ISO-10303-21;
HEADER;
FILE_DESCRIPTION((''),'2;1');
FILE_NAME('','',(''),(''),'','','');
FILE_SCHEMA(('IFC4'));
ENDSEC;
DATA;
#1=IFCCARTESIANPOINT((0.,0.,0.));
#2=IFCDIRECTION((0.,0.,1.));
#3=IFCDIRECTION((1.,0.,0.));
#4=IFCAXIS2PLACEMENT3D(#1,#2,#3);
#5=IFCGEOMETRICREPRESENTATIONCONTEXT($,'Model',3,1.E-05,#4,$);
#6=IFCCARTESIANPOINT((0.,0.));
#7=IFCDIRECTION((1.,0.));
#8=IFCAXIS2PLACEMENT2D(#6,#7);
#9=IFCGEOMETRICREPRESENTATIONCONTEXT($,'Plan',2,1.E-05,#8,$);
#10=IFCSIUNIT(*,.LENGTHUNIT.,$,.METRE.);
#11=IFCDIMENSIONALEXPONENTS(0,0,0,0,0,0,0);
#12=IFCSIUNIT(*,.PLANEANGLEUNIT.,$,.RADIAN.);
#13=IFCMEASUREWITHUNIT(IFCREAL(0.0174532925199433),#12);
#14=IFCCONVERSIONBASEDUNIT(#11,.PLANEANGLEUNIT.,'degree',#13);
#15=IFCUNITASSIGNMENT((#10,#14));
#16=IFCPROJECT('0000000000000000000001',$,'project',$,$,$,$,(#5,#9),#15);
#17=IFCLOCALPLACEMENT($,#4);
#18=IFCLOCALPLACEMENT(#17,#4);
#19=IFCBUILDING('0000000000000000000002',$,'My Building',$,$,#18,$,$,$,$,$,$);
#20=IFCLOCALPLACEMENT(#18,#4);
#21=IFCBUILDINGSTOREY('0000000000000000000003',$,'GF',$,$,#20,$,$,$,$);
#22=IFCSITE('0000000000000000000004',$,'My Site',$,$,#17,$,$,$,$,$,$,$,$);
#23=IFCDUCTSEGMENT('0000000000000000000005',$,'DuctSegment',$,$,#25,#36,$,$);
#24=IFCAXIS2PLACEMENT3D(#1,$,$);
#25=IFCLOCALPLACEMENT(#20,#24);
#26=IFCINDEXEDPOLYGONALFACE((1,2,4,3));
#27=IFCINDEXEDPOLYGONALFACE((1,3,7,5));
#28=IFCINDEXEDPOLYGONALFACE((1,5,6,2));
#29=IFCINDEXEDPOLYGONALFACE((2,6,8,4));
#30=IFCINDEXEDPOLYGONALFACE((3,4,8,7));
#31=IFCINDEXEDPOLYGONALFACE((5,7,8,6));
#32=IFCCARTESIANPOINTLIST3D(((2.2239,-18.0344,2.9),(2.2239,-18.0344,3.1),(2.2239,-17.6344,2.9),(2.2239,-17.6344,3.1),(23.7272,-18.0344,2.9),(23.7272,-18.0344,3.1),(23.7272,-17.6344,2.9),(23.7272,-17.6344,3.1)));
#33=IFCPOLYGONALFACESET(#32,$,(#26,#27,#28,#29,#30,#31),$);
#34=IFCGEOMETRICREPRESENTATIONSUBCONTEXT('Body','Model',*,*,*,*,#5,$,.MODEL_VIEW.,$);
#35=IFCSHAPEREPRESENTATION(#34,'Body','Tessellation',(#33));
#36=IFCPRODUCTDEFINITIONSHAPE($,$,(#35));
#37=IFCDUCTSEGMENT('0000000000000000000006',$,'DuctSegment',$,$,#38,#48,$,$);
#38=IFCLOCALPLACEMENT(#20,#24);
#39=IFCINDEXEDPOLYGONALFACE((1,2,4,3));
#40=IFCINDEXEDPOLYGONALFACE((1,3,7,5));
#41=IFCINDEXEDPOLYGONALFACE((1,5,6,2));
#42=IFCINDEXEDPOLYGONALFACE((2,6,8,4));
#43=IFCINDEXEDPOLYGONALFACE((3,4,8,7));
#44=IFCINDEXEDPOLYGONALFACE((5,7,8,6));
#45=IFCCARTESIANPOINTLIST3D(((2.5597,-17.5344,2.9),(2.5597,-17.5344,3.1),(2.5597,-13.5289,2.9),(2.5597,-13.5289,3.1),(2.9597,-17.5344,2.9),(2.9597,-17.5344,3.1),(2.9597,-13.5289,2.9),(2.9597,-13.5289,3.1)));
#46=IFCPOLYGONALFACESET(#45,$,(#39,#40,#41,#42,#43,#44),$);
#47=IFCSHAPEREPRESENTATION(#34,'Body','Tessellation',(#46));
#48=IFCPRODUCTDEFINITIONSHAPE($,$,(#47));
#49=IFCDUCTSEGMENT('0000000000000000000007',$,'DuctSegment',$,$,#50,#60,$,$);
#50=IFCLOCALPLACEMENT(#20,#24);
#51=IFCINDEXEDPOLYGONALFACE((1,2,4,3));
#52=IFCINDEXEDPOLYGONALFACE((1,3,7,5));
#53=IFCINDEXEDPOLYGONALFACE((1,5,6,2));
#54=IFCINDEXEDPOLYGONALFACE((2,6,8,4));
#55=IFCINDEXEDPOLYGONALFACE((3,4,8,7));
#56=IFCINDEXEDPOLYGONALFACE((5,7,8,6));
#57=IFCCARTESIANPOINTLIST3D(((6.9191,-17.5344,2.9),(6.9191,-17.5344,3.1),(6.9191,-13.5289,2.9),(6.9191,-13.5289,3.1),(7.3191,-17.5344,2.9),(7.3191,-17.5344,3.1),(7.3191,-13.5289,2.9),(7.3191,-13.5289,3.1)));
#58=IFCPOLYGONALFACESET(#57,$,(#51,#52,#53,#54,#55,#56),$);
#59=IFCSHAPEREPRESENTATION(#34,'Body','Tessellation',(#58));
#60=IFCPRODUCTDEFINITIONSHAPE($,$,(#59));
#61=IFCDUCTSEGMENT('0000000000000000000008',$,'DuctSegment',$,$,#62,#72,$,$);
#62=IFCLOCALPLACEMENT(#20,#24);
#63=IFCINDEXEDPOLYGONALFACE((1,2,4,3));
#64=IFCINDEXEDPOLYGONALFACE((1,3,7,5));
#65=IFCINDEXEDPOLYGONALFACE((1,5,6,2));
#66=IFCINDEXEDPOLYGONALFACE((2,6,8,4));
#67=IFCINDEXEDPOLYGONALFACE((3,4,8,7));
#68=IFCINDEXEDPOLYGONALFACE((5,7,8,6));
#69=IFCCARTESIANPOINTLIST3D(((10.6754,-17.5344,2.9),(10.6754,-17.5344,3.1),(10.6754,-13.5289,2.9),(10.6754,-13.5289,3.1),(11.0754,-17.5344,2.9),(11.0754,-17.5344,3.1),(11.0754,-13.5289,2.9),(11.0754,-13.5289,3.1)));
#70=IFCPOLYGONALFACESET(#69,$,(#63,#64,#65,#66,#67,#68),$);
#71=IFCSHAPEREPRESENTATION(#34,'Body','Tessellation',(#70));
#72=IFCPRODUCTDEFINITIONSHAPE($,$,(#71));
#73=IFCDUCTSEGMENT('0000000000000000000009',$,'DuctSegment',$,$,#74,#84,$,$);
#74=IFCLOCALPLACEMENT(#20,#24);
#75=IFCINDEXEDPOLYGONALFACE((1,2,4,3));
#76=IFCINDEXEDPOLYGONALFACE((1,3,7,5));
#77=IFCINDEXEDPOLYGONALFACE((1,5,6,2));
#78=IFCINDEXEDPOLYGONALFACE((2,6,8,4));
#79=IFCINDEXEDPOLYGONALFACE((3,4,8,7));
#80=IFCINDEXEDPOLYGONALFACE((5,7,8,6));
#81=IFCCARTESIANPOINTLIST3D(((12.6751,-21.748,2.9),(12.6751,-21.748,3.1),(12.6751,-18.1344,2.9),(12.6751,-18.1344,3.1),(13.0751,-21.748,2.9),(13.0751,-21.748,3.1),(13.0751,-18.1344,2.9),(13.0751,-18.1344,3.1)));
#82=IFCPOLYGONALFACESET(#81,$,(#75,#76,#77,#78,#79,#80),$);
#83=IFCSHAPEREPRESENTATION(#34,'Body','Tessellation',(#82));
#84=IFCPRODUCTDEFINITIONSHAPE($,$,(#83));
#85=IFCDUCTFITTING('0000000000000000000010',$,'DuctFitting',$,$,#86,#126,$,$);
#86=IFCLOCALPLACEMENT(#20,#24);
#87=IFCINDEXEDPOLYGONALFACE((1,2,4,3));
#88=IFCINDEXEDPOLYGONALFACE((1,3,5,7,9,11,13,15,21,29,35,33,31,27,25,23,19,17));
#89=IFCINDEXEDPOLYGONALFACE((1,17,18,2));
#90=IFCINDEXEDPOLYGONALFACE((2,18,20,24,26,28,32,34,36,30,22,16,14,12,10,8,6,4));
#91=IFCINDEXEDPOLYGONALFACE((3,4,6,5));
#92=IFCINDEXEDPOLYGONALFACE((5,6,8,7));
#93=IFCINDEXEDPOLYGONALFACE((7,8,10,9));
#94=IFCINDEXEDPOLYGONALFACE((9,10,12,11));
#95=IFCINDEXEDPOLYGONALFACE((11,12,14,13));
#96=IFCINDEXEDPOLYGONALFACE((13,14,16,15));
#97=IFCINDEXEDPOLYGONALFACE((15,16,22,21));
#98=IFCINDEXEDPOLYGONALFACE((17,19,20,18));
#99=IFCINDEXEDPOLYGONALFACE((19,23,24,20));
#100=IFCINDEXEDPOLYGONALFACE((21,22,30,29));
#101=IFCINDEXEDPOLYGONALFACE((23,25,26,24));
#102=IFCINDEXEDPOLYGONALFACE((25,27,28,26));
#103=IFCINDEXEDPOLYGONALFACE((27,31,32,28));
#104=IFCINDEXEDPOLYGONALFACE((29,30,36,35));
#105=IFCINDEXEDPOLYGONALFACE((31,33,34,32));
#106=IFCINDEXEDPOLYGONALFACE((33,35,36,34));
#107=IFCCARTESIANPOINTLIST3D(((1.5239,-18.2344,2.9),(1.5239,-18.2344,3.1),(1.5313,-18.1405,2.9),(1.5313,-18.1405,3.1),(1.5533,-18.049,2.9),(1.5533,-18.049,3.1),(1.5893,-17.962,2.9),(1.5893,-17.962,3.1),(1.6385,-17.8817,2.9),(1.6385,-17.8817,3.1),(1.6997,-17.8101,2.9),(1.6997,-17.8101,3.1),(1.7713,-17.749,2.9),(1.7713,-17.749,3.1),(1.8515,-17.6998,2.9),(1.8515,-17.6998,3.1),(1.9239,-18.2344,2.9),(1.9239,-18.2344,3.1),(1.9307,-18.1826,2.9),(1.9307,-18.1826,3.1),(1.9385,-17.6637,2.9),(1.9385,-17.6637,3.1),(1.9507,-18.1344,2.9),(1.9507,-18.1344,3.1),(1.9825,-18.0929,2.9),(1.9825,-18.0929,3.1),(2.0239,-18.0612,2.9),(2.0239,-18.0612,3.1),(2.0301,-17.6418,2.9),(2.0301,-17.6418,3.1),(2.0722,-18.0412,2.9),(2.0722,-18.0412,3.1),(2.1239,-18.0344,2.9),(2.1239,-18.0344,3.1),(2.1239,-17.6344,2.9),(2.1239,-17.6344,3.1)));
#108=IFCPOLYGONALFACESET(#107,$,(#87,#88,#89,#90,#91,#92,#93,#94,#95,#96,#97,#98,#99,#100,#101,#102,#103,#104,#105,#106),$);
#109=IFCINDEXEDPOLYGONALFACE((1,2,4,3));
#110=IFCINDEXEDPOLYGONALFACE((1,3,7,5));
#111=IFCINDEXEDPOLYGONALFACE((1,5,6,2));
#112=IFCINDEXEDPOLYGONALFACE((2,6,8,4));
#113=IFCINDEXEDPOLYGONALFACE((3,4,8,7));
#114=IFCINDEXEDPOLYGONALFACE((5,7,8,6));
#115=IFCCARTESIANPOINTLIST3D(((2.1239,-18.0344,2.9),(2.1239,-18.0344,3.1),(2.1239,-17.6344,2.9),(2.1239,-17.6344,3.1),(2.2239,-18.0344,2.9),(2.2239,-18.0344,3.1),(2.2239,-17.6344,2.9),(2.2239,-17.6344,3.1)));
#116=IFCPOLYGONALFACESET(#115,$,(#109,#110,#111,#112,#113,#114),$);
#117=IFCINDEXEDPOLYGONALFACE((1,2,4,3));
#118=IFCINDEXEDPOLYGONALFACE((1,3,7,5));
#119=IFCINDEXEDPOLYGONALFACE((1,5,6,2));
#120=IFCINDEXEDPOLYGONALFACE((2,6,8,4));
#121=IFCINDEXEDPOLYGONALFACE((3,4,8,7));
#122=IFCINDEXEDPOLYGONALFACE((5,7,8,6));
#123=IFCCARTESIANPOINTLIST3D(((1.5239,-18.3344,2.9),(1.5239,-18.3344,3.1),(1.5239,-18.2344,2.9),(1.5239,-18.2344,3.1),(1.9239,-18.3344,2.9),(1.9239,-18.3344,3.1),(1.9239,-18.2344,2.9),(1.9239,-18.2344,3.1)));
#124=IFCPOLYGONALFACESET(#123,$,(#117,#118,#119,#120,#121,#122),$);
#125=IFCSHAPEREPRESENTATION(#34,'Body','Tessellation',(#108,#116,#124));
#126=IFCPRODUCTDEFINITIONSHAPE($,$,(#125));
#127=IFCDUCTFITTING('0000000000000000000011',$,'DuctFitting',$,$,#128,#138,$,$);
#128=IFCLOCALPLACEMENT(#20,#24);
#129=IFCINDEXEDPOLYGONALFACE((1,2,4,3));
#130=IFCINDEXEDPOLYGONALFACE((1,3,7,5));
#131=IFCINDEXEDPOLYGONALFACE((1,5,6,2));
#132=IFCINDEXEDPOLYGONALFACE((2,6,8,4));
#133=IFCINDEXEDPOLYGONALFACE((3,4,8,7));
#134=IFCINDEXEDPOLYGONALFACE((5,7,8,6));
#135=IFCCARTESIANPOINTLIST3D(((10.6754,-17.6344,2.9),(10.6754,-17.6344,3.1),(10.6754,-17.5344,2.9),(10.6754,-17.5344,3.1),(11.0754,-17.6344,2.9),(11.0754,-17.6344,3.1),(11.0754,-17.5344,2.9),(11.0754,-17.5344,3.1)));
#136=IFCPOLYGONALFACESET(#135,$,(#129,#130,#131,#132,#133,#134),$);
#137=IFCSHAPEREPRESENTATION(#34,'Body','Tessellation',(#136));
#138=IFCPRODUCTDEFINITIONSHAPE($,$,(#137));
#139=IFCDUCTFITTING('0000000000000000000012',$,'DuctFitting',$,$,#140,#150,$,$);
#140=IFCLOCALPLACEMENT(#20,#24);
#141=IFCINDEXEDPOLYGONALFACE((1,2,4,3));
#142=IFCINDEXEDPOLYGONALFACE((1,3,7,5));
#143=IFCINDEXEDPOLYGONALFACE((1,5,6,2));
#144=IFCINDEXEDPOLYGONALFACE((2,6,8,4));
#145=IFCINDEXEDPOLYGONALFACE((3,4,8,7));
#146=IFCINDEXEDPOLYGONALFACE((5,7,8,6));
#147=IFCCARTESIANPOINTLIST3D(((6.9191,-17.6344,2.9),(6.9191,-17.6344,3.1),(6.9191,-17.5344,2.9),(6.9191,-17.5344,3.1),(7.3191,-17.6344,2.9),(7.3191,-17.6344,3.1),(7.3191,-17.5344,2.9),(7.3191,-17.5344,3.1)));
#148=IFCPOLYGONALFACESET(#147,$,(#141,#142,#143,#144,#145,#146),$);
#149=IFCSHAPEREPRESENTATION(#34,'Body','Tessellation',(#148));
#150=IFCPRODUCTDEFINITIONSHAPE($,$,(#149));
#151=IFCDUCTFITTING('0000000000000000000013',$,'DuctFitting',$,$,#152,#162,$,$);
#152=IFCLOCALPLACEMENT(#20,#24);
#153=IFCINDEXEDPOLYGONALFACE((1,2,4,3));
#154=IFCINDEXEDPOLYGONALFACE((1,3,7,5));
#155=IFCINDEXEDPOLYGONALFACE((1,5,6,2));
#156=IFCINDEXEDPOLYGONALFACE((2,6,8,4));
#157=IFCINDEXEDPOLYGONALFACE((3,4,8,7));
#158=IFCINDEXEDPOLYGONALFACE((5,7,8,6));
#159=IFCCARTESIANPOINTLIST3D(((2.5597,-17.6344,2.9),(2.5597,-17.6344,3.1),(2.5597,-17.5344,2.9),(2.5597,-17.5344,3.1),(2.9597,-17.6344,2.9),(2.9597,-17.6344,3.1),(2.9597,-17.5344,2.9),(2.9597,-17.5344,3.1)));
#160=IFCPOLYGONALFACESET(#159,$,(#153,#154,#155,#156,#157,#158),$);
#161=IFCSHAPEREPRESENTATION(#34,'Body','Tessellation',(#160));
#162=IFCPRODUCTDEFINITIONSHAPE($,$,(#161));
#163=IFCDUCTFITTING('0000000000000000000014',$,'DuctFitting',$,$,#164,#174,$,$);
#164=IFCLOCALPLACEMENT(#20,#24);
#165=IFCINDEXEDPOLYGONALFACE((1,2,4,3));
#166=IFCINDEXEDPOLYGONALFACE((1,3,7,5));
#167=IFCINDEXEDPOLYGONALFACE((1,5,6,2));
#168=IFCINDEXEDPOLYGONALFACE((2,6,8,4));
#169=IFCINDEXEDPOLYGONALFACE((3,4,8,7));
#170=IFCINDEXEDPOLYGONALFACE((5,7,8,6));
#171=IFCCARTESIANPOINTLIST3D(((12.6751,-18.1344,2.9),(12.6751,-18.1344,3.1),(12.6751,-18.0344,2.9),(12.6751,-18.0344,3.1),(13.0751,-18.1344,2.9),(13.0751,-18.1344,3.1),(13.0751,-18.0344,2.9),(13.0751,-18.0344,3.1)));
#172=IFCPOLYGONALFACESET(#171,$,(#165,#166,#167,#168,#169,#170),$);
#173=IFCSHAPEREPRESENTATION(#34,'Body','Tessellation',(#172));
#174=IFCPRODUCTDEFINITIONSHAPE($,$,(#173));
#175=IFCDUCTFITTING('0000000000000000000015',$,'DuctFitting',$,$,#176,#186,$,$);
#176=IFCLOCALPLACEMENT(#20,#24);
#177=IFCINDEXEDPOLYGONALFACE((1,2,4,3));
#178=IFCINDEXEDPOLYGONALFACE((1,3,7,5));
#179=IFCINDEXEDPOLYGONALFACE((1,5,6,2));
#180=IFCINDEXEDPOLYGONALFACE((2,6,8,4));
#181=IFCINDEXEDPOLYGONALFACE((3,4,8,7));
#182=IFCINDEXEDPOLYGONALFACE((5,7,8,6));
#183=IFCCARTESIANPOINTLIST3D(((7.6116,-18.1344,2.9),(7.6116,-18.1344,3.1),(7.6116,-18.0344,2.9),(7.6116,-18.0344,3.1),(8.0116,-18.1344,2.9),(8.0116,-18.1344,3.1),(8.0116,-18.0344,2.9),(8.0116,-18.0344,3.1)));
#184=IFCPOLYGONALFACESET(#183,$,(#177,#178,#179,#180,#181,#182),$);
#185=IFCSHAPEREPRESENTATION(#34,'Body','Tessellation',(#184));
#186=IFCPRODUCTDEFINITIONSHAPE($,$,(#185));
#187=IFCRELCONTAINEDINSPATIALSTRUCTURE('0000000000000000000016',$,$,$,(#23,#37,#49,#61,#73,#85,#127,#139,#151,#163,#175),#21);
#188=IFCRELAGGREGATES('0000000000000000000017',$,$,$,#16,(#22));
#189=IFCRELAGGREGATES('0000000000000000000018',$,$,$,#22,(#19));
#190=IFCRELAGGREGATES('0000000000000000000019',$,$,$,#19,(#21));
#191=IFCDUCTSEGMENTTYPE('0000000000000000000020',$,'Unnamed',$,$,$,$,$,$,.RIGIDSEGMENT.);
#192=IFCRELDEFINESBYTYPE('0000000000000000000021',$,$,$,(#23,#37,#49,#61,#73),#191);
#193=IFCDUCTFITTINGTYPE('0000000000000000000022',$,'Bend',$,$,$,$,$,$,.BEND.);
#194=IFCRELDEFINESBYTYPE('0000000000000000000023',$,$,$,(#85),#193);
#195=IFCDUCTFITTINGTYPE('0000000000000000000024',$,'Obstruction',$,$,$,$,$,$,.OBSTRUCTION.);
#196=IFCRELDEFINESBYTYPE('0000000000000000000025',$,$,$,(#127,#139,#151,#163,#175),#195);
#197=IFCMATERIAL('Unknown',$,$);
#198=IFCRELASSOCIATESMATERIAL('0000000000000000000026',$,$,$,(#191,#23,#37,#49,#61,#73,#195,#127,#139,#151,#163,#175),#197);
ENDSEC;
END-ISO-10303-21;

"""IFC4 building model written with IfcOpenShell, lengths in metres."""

from ifc_helpers import new_model, entity, si_unit, converted_unit, frame, origin_with_axes, origin_2d_with_axis, place, context, subcontext, project, spatial, line, arc, indexed_curve, rectangle, outline, extrude, source, transform, mapped, material, material_profile, profile_set, profile_usage, type_object, type_shapes, element, save


model = new_model("IFC4")

# Units and contexts
model_context = context("Model", 3, precision=1e-05, world=origin_with_axes())
plan_context = context("Plan", 2, precision=1e-05, world=origin_2d_with_axis())
body_context_1 = subcontext(model_context, "Body", "Model", "MODEL_VIEW")
ifc_project = project(units=[si_unit("LENGTHUNIT", "METRE"), converted_unit("PLANEANGLEUNIT", "degree", entity("IfcReal", 0.0174532925199433), si_unit("PLANEANGLEUNIT", "RADIAN"), dimensions=[0, 0, 0, 0, 0, 0, 0])], contexts=[model_context, plan_context])

# Site, building, storey
site_placement = place(None, origin_with_axes())
site = spatial("IfcSite", under=ifc_project, at=site_placement, Name="My Site")
building_placement = place(site_placement, origin_with_axes())
building = spatial("IfcBuilding", under=site, at=building_placement, Name="My Building")
storey_placement = place(building_placement, origin_with_axes())
storey = spatial("IfcBuildingStorey", under=building, at=storey_placement, Name="GF")

# Shared definitions
ifc_material = material(Name="Unknown")

# Duct segments
ifc_material_profile_1 = material_profile(ifc_material, rectangle(XDim=0.4, YDim=0.2))
ifc_profile_set_1 = profile_set([ifc_material_profile_1])
ifc_profile_usage_1 = profile_usage(ifc_profile_set_1, cardinal=5)
duct_segment_type = type_object("IfcDuctSegmentType", Name="Unnamed", PredefinedType="RIGIDSEGMENT", material=ifc_profile_set_1)
duct_segment_1_placement = place(storey_placement, frame((2.2239, -17.8344, 3.0), z_axis=(1.0, -0.000001, 0.000001), x_axis=(0.000001, 1.0, 0.0)))
element("IfcDuctSegment", 1, at=duct_segment_1_placement, inside=storey, type_object=duct_segment_type, material=ifc_profile_usage_1, Name="DuctSegment", context=body_context_1, shape_type="SweptSolid", body=[
    extrude(rectangle(XDim=0.4, YDim=0.2), origin_with_axes(), (0.0, 0.0, 1.0), 21.5032),
])
ifc_profile_usage_2 = profile_usage(ifc_profile_set_1, cardinal=5)
duct_segment_2_placement = place(storey_placement, frame((2.7597, -17.5344, 3.0), z_axis=(0.0, 1.0, 0.0), x_axis=(-1.0, 0.0, 0.0)))
element("IfcDuctSegment", 2, at=duct_segment_2_placement, inside=storey, type_object=duct_segment_type, material=ifc_profile_usage_2, Name="DuctSegment", context=body_context_1, shape_type="SweptSolid", body=[
    extrude(rectangle(XDim=0.4, YDim=0.2), origin_with_axes(), (0.0, 0.0, 1.0), 4.0055),
])
ifc_profile_usage_3 = profile_usage(ifc_profile_set_1, cardinal=5)
duct_segment_3_placement = place(storey_placement, frame((7.1191, -17.5344, 3.0), z_axis=(0.0, 1.0, 0.0), x_axis=(-1.0, 0.0, 0.0)))
element("IfcDuctSegment", 3, at=duct_segment_3_placement, inside=storey, type_object=duct_segment_type, material=ifc_profile_usage_3, Name="DuctSegment", context=body_context_1, shape_type="SweptSolid", body=[
    extrude(rectangle(XDim=0.4, YDim=0.2), origin_with_axes(), (0.0, 0.0, 1.0), 4.0055),
])
ifc_profile_usage_4 = profile_usage(ifc_profile_set_1, cardinal=5)
duct_segment_4_placement = place(storey_placement, frame((10.8754, -17.5344, 3.0), z_axis=(0.0, 1.0, 0.0), x_axis=(-1.0, 0.0, 0.0)))
element("IfcDuctSegment", 4, at=duct_segment_4_placement, inside=storey, type_object=duct_segment_type, material=ifc_profile_usage_4, Name="DuctSegment", context=body_context_1, shape_type="SweptSolid", body=[
    extrude(rectangle(XDim=0.4, YDim=0.2), origin_with_axes(), (0.0, 0.0, 1.0), 4.0055),
])
ifc_profile_usage_5 = profile_usage(ifc_profile_set_1, cardinal=5)
duct_segment_5_placement = place(storey_placement, frame((12.8751, -18.1344, 3.0), z_axis=(0.0, -1.0, 0.0), x_axis=(1.0, 0.0, 0.0)))
element("IfcDuctSegment", 5, at=duct_segment_5_placement, inside=storey, type_object=duct_segment_type, material=ifc_profile_usage_5, Name="DuctSegment", context=body_context_1, shape_type="SweptSolid", body=[
    extrude(rectangle(XDim=0.4, YDim=0.2), origin_with_axes(), (0.0, 0.0, 1.0), 3.6136),
])

# Duct fittings
duct_fitting_type_1 = type_object("IfcDuctFittingType", Name="Bend", PredefinedType="BEND")
shared_shape_1 = source(origin_with_axes(), body_context_1, "Body", "SweptSolid", [
    extrude(outline(indexed_curve([(-0.2, 0.0), (-0.2586, -0.1414), (-0.4, -0.2), (-0.4, -0.6), (0.0243, -0.4243), (0.2, 0.0)], segments=[arc(1, 2, 3), line(3, 4), arc(4, 5, 6), line(6, 1)])), frame((0.0, -0.1, -0.1), z_axis=(0.0, -1.0, 0.0), x_axis=(1.0, 0.0, 0.0)), (0.0, 0.0, -1.0), 0.2),
    extrude(rectangle(XDim=0.4, YDim=0.2), origin_with_axes(), (0.0, 0.0, -1.0), 0.1),
    extrude(rectangle(XDim=0.4, YDim=0.2), frame((-0.4, 0.0, -0.5), z_axis=(-1.0, 0.0, 0.0), x_axis=(0.0, 0.0, -1.0)), (0.0, 0.0, 1.0), 0.1),
])
type_shapes(duct_fitting_type_1, [shared_shape_1])
duct_fitting_1_placement = place(storey_placement, frame((2.2239, -17.8344, 3.0), z_axis=(1.0, -0.000001, 0.000001), x_axis=(0.000001, 1.0, 0.0)))
element("IfcDuctFitting", 6, at=duct_fitting_1_placement, inside=storey, type_object=duct_fitting_type_1, Name="DuctFitting", context=body_context_1, shape_type="MappedRepresentation", body=[
    mapped(shared_shape_1, transform((0.0, 0.0, 0.0), x_axis=(1.0, 0.0, 0.0), y_axis=(0.0, 1.0, 0.0), z_axis=(0.0, 0.0, 1.0), scale=1.0)),
])
ifc_material_profile_2 = material_profile(ifc_material, rectangle(XDim=0.4, YDim=0.2))
ifc_profile_set_2 = profile_set([ifc_material_profile_2])
ifc_profile_usage_6 = profile_usage(ifc_profile_set_2, cardinal=5)
duct_fitting_type_2 = type_object("IfcDuctFittingType", Name="Obstruction", PredefinedType="OBSTRUCTION", material=ifc_profile_set_2)
duct_fitting_2_placement = place(storey_placement, frame((10.8754, -17.6344, 3.0), z_axis=(0.0, 1.0, 0.0), x_axis=(-1.0, 0.0, 0.0)))
element("IfcDuctFitting", 7, at=duct_fitting_2_placement, inside=storey, type_object=duct_fitting_type_2, material=ifc_profile_usage_6, Name="DuctFitting", context=body_context_1, shape_type="SweptSolid", body=[
    extrude(rectangle(XDim=0.4, YDim=0.2), origin_with_axes(), (0.0, 0.0, 1.0), 0.1),
])
ifc_profile_usage_7 = profile_usage(ifc_profile_set_2, cardinal=5)
duct_fitting_3_placement = place(storey_placement, frame((7.1191, -17.6344, 3.0), z_axis=(0.0, 1.0, 0.0), x_axis=(-1.0, 0.0, 0.0)))
element("IfcDuctFitting", 8, at=duct_fitting_3_placement, inside=storey, type_object=duct_fitting_type_2, material=ifc_profile_usage_7, Name="DuctFitting", context=body_context_1, shape_type="SweptSolid", body=[
    extrude(rectangle(XDim=0.4, YDim=0.2), origin_with_axes(), (0.0, 0.0, 1.0), 0.1),
])
ifc_profile_usage_8 = profile_usage(ifc_profile_set_2, cardinal=5)
duct_fitting_4_placement = place(storey_placement, frame((2.7597, -17.6344, 3.0), z_axis=(0.0, 1.0, 0.0), x_axis=(-1.0, 0.0, 0.0)))
element("IfcDuctFitting", 9, at=duct_fitting_4_placement, inside=storey, type_object=duct_fitting_type_2, material=ifc_profile_usage_8, Name="DuctFitting", context=body_context_1, shape_type="SweptSolid", body=[
    extrude(rectangle(XDim=0.4, YDim=0.2), origin_with_axes(), (0.0, 0.0, 1.0), 0.1),
])
ifc_profile_usage_9 = profile_usage(ifc_profile_set_2, cardinal=5)
duct_fitting_5_placement = place(storey_placement, frame((12.8751, -18.0344, 3.0), z_axis=(0.0, -1.0, 0.0), x_axis=(1.0, 0.0, 0.0)))
element("IfcDuctFitting", 10, at=duct_fitting_5_placement, inside=storey, type_object=duct_fitting_type_2, material=ifc_profile_usage_9, Name="DuctFitting", context=body_context_1, shape_type="SweptSolid", body=[
    extrude(rectangle(XDim=0.4, YDim=0.2), origin_with_axes(), (0.0, 0.0, 1.0), 0.1),
])
ifc_profile_usage_10 = profile_usage(ifc_profile_set_2, cardinal=5)
duct_fitting_6_placement = place(storey_placement, frame((7.8116, -18.0344, 3.0), z_axis=(0.0, -1.0, 0.0), x_axis=(1.0, 0.0, 0.0)))
element("IfcDuctFitting", 11, at=duct_fitting_6_placement, inside=storey, type_object=duct_fitting_type_2, material=ifc_profile_usage_10, Name="DuctFitting", context=body_context_1, shape_type="SweptSolid", body=[
    extrude(rectangle(XDim=0.4, YDim=0.2), origin_with_axes(), (0.0, 0.0, 1.0), 0.1),
])

save(model, "model.ifc")
